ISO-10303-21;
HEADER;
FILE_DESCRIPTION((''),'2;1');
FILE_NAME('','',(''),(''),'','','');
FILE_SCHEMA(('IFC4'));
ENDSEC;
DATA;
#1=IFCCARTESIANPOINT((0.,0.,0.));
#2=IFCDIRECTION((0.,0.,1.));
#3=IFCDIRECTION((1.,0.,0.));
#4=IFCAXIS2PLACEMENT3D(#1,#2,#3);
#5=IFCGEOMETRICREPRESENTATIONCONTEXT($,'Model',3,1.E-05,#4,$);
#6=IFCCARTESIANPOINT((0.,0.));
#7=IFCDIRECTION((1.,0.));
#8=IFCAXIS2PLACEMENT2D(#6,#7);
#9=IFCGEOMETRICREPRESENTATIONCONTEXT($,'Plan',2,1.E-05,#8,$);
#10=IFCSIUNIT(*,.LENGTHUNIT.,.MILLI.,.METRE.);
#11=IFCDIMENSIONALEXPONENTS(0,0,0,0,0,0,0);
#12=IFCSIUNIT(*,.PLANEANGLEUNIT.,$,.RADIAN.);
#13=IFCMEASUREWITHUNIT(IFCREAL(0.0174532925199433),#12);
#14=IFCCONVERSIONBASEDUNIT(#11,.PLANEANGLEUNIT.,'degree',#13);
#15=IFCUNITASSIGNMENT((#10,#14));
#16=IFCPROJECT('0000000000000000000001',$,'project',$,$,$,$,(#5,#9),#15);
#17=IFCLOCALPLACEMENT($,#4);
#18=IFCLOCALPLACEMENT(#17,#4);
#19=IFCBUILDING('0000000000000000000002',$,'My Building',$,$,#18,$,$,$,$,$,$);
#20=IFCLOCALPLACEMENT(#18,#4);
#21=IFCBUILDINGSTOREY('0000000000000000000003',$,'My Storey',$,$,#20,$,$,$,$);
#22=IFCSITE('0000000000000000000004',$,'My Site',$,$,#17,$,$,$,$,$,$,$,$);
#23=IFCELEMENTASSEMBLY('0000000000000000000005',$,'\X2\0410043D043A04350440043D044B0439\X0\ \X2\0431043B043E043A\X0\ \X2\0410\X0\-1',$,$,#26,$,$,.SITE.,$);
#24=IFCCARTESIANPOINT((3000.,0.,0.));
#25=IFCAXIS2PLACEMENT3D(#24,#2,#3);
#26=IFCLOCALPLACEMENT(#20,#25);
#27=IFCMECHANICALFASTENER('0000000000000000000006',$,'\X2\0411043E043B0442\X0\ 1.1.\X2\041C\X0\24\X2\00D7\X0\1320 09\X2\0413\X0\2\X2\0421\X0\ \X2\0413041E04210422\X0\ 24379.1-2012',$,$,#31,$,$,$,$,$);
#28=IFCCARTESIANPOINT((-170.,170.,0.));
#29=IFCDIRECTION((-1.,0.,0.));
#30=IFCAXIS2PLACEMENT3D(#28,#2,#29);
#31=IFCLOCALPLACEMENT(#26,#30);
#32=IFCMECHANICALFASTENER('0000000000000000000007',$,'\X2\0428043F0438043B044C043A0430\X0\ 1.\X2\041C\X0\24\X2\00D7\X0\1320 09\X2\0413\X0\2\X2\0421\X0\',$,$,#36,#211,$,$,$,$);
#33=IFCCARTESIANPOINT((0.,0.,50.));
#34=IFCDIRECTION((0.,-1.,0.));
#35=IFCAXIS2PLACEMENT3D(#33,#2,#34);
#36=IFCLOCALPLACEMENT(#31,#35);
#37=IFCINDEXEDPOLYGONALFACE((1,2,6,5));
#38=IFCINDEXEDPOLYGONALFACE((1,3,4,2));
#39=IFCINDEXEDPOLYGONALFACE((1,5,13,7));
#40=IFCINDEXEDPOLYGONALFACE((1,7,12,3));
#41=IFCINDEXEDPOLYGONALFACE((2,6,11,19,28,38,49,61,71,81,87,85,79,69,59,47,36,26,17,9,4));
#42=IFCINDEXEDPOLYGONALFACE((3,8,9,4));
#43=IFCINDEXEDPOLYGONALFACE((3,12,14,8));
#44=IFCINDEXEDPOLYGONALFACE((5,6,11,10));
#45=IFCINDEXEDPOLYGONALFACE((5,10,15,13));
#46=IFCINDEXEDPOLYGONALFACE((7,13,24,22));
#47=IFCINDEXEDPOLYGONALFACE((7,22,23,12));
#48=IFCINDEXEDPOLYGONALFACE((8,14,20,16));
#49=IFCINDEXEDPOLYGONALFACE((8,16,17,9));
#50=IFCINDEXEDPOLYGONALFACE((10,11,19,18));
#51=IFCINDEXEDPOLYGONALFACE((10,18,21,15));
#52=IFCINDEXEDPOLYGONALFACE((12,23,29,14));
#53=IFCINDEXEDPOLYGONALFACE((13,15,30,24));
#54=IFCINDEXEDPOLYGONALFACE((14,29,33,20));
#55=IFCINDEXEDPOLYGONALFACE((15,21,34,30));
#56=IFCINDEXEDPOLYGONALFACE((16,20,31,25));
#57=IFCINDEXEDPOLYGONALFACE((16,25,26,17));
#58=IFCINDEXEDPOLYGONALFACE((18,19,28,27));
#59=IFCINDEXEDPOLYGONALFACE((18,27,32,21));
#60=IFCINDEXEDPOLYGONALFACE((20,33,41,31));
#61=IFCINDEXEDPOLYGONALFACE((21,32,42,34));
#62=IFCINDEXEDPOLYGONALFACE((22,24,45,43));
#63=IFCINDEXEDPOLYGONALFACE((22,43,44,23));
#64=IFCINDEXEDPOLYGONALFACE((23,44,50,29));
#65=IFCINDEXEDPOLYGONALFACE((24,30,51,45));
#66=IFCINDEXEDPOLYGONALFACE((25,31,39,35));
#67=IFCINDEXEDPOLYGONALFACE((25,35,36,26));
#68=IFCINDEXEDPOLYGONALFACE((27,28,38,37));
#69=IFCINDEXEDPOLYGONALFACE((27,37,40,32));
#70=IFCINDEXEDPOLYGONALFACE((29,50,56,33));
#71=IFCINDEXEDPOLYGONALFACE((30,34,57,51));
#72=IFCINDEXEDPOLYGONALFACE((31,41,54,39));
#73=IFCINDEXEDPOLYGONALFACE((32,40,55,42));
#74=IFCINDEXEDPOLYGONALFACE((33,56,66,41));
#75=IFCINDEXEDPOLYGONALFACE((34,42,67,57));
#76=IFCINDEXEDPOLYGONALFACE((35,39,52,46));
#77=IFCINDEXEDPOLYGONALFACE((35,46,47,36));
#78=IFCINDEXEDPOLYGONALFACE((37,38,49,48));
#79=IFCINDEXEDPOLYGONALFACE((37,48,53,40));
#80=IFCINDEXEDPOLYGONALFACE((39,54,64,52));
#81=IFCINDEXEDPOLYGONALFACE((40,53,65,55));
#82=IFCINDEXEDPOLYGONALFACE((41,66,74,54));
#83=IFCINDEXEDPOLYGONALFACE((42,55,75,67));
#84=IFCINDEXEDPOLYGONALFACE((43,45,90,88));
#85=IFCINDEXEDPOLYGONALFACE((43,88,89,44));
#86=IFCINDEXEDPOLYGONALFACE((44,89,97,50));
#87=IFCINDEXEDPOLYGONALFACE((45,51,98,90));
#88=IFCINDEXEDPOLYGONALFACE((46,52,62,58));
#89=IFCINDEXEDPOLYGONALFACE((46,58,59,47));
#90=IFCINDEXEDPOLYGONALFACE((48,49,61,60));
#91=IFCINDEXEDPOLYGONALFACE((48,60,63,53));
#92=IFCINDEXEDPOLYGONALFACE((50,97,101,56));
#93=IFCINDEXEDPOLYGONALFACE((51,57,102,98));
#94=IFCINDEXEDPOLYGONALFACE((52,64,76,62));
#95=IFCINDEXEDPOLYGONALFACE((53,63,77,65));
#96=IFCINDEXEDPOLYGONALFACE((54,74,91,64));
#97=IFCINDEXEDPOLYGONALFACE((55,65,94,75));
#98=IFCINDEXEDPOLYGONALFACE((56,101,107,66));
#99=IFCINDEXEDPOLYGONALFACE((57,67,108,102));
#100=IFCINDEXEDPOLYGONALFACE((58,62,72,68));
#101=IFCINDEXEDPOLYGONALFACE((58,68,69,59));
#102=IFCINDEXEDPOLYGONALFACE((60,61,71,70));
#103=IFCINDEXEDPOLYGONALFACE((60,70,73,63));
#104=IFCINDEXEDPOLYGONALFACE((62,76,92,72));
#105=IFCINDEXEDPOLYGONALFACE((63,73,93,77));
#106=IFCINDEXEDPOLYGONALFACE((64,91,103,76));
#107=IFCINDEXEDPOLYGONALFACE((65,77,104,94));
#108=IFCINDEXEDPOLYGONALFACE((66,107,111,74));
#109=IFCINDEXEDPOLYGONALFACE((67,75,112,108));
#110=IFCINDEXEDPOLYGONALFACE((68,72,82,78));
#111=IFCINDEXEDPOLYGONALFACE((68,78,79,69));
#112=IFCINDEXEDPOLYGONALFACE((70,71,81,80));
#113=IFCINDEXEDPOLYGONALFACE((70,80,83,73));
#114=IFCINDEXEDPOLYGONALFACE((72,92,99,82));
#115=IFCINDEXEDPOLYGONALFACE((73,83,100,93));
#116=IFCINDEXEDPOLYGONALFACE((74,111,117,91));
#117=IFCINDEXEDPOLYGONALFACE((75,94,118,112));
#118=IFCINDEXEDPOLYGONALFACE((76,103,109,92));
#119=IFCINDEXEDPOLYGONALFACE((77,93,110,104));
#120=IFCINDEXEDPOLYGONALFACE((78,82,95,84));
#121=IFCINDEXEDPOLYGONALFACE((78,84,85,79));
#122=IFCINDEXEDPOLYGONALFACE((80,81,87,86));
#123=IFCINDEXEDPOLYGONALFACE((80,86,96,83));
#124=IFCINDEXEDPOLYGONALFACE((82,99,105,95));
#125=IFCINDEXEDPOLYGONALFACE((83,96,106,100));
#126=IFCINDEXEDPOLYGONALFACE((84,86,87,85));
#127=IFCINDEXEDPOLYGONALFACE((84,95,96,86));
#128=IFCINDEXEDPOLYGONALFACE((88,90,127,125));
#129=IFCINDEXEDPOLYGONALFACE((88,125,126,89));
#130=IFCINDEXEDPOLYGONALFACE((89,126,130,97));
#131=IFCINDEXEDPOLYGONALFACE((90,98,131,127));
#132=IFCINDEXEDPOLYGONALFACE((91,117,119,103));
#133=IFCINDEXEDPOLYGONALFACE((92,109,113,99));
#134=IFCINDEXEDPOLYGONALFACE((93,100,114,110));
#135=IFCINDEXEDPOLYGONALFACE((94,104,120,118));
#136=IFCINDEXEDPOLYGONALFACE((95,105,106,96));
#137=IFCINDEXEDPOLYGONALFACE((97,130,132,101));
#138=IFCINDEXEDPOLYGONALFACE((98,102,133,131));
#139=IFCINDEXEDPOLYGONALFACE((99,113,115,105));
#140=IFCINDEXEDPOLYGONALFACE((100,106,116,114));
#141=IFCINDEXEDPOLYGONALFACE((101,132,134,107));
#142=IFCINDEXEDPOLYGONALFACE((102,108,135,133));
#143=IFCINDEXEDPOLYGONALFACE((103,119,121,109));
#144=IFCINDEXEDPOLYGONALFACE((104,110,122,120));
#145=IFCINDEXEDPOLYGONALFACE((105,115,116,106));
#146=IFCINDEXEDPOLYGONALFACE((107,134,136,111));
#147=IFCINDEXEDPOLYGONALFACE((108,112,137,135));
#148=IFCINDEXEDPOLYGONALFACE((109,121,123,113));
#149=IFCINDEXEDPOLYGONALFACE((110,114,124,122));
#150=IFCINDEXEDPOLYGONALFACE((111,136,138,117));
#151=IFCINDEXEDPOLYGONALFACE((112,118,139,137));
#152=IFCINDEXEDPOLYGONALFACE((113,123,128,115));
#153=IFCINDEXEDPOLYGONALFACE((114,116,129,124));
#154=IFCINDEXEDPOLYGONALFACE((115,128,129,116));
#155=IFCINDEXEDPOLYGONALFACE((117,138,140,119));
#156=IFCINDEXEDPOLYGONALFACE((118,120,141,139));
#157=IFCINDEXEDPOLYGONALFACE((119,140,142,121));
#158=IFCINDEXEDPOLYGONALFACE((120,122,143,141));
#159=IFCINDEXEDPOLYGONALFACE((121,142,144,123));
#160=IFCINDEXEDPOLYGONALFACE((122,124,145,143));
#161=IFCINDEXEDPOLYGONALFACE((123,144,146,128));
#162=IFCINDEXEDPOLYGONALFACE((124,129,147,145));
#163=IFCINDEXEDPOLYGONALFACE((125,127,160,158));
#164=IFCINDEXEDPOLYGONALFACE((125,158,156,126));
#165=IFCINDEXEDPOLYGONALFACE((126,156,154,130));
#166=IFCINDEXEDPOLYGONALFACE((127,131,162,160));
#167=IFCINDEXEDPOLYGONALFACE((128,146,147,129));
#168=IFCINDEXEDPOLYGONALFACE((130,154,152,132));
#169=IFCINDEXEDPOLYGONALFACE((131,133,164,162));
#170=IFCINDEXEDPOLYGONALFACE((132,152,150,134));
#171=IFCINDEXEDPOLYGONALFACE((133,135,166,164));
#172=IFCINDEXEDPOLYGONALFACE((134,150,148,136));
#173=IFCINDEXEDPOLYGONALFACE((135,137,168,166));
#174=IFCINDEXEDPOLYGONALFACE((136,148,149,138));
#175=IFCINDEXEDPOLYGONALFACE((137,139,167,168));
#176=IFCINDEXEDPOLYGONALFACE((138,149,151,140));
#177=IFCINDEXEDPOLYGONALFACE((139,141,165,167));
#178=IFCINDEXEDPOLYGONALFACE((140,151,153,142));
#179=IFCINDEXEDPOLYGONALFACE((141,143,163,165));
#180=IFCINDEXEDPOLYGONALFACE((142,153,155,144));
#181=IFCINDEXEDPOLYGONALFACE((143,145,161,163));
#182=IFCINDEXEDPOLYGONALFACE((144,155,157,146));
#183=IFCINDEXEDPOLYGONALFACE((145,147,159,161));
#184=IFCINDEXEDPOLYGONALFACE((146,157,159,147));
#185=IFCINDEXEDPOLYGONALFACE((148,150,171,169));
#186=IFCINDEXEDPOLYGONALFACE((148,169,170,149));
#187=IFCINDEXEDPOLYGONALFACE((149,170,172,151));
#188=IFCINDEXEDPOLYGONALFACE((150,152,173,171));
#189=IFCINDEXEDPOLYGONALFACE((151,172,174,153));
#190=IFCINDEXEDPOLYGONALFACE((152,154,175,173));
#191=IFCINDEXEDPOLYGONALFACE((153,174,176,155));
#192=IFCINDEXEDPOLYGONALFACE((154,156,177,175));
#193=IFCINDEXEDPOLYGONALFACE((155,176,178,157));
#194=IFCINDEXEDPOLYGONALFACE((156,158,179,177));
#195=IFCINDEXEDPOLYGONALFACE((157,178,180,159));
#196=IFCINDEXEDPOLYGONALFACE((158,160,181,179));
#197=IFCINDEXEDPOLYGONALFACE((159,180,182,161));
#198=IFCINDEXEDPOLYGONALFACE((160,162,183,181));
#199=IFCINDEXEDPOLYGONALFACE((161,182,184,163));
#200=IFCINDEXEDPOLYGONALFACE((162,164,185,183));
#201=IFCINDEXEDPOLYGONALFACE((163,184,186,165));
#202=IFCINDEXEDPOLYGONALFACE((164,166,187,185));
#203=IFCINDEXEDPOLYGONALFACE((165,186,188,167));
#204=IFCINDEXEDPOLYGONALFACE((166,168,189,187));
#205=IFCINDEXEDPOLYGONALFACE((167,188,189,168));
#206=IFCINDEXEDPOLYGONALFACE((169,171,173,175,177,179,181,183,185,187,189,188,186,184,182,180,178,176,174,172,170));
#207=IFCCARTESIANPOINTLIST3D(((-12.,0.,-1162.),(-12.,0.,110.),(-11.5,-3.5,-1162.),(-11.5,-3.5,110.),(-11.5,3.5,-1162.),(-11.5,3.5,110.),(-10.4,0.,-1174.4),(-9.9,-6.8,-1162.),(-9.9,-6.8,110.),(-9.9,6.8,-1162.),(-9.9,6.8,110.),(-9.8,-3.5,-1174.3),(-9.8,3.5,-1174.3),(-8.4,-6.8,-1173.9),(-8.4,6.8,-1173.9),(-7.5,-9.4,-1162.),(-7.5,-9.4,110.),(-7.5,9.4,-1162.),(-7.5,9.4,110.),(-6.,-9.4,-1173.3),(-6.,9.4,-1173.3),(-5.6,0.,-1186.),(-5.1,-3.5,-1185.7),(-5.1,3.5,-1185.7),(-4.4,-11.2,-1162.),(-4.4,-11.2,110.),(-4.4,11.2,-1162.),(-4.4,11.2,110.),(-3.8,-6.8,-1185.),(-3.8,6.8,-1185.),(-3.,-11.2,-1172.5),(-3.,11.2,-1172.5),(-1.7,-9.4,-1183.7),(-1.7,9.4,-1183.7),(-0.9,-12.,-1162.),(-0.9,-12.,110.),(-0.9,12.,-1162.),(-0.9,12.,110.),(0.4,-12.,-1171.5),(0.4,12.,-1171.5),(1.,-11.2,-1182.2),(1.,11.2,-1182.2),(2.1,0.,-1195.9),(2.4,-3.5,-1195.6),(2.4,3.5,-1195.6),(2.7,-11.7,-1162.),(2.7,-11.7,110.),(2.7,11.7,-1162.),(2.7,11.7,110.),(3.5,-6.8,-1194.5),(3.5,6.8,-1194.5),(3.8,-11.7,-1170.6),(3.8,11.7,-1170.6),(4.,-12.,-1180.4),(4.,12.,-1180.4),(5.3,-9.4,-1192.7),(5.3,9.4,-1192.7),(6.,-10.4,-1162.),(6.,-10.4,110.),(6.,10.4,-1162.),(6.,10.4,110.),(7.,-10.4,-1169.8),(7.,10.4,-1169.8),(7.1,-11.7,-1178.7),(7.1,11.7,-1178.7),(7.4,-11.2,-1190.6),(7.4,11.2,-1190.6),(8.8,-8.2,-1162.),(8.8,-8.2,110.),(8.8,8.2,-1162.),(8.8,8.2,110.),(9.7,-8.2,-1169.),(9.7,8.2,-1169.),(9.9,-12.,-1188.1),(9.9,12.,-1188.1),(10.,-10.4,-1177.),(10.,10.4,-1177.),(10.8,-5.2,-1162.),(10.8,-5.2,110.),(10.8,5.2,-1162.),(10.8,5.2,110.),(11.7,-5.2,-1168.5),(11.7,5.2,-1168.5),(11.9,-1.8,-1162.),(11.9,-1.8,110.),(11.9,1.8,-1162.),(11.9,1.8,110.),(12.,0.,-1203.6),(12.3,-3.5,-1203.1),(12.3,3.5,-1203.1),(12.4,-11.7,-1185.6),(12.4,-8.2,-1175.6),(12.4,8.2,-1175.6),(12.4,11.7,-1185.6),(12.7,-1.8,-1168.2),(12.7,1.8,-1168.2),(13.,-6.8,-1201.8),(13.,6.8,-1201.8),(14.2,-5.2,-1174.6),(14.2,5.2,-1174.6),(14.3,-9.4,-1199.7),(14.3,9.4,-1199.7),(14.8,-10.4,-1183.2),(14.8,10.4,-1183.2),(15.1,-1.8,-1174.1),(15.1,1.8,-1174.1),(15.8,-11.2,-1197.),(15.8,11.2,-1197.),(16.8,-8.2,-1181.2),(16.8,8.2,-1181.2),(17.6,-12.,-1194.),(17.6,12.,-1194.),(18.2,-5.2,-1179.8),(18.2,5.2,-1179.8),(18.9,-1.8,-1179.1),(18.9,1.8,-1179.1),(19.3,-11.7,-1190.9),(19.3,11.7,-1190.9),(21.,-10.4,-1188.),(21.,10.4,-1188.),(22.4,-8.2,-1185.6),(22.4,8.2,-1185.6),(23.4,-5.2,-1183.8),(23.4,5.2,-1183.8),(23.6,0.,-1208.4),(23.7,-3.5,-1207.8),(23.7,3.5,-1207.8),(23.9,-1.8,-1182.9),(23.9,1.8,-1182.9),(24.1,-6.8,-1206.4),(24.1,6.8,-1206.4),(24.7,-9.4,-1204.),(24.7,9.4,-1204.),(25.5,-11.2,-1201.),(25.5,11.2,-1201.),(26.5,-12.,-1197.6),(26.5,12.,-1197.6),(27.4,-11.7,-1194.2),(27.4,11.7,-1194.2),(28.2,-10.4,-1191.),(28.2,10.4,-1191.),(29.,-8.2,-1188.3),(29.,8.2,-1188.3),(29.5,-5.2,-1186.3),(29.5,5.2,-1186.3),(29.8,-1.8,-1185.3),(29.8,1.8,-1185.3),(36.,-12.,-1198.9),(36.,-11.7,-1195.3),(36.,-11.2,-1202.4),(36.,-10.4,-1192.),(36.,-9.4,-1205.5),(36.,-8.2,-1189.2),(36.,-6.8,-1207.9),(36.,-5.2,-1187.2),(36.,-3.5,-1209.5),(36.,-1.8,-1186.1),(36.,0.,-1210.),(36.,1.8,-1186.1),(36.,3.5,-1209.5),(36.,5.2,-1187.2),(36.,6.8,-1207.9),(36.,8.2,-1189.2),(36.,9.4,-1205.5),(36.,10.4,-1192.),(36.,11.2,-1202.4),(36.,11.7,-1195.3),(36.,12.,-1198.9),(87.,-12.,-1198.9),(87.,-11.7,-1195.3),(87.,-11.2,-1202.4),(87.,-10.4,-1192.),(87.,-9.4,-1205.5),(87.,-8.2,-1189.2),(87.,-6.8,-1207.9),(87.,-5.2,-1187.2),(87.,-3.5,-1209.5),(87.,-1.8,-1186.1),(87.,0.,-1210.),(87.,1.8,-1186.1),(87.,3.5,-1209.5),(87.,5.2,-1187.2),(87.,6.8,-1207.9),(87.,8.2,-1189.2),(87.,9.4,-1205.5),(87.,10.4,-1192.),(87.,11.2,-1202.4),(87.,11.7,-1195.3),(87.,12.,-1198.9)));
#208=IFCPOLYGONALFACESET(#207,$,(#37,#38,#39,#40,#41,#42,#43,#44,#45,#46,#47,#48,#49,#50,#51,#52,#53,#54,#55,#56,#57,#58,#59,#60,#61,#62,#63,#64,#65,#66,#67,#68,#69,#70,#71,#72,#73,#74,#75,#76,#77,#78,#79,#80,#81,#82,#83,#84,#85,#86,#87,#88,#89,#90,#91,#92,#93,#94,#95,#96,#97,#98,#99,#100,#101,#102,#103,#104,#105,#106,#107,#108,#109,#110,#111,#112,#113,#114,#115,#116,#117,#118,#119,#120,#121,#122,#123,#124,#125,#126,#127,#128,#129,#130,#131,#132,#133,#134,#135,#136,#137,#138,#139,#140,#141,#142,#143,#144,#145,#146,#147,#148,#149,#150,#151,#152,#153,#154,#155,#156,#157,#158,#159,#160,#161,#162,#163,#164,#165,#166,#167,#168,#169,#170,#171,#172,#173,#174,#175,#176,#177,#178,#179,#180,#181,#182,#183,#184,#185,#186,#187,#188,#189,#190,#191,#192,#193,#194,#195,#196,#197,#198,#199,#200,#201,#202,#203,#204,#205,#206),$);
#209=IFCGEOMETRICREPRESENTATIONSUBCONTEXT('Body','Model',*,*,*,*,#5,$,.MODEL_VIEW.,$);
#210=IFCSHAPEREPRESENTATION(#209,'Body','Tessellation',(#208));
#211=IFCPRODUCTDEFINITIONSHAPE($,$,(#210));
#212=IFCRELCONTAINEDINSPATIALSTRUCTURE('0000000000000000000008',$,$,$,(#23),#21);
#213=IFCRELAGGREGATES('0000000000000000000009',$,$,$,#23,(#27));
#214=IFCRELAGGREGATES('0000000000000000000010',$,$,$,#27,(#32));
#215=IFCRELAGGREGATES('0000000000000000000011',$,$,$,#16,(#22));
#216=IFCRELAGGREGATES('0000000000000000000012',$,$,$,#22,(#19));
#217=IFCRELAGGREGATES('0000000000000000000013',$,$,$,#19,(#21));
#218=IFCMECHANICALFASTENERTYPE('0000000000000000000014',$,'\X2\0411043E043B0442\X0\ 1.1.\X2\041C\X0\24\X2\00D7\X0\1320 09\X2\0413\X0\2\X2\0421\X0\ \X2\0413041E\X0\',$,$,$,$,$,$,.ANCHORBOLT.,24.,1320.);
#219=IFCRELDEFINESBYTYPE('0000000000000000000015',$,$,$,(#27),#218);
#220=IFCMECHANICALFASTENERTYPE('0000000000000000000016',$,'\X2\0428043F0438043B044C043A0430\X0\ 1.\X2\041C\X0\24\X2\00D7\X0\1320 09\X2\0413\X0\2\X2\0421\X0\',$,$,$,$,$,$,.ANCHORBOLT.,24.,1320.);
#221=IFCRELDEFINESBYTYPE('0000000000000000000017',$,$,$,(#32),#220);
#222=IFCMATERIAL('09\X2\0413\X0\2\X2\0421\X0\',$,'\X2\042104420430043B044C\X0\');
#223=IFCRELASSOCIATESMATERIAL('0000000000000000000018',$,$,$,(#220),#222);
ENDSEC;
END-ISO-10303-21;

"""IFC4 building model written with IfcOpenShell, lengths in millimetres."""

from ifc_helpers import new_model, entity, si_unit, converted_unit, frame, origin_with_axes, origin_2d_with_axis, place, context, subcontext, project, spatial, source, transform, mapped, material, type_object, type_shapes, element, aggregate, save


model = new_model("IFC4")

# Units and contexts
model_context = context("Model", 3, precision=1e-05, world=origin_with_axes())
plan_context = context("Plan", 2, precision=1e-05, world=origin_2d_with_axis())
body_context = subcontext(model_context, "Body", "Model", "MODEL_VIEW")
ifc_project = project(units=[si_unit("LENGTHUNIT", "METRE", prefix="MILLI"), converted_unit("PLANEANGLEUNIT", "degree", entity("IfcReal", 0.0174532925199433), si_unit("PLANEANGLEUNIT", "RADIAN"), dimensions=[0, 0, 0, 0, 0, 0, 0])], contexts=[model_context, plan_context])

# Site, building, storey
site_placement = place(None, origin_with_axes())
site = spatial("IfcSite", under=ifc_project, at=site_placement, Name="My Site")
building_placement = place(site_placement, origin_with_axes())
building = spatial("IfcBuilding", under=site, at=building_placement, Name="My Building")
storey_placement = place(building_placement, origin_with_axes())
storey = spatial("IfcBuildingStorey", under=building, at=storey_placement, Name="My Storey")

# Element assembly, mechanical fasteners
assembly_placement = place(storey_placement, frame((3000.0, 0.0, 0.0), z_axis=(0.0, 0.0, 1.0), x_axis=(1.0, 0.0, 0.0)))
assembly = element("IfcElementAssembly", 1, at=assembly_placement, inside=storey, Name="Анкерный блок А-1", AssemblyPlace="SITE")
mechanical_fastener_type_1 = type_object("IfcMechanicalFastenerType", Name="Болт 1.1.М24×1320 09Г2С ГО", NominalDiameter=24.0, NominalLength=1320.0, PredefinedType="ANCHORBOLT")
mechanical_fastener_1_placement = place(assembly_placement, frame((-170.0, 170.0, 0.0), z_axis=(0.0, 0.0, 1.0), x_axis=(-1.0, 0.0, 0.0)))
mechanical_fastener_1 = element("IfcMechanicalFastener", 2, at=mechanical_fastener_1_placement, type_object=mechanical_fastener_type_1, Name="Болт 1.1.М24×1320 09Г2С ГОСТ 24379.1-2012")
ifc_material_1 = material(Name="09Г2С", Category="Сталь")
mechanical_fastener_type_2 = type_object("IfcMechanicalFastenerType", Name="Шпилька 1.М24×1320 09Г2С", NominalDiameter=24.0, NominalLength=1320.0, PredefinedType="ANCHORBOLT", material=ifc_material_1)
shared_shape_1 = source(frame((0.0, 0.0, 110.0), z_axis=(0.0, 0.0, 1.0), x_axis=(1.0, 0.0, 0.0)), body_context, "Body", "AdvancedSweptSolid", [
    entity("IfcSweptDiskSolid", entity("IfcIndexedPolyCurve", entity("IfcCartesianPointList3D", [[0.0, 0.0, 0.0], [0.0, 0.0, -1272.0], [10.5, 0.0, -1297.5], [36.0, 0.0, -1308.0], [87.0, 0.0, -1308.0]]), [entity("IfcLineIndex", [1, 2]), entity("IfcArcIndex", [2, 3, 4]), entity("IfcLineIndex", [4, 5])]), 12.0),
])
type_shapes(mechanical_fastener_type_2, [shared_shape_1])
mechanical_fastener_2_placement = place(mechanical_fastener_1_placement, frame((0.0, 0.0, 50.0), z_axis=(0.0, 0.0, 1.0), x_axis=(0.0, -1.0, 0.0)))
mechanical_fastener_2 = element("IfcMechanicalFastener", 3, at=mechanical_fastener_2_placement, type_object=mechanical_fastener_type_2, Name="Шпилька 1.М24×1320 09Г2С", context=body_context, shape_type="MappedRepresentation", body=[
    mapped(shared_shape_1, transform((0.0, 0.0, 0.0), x_axis=(1.0, 0.0, 0.0), y_axis=(0.0, 1.0, 0.0), z_axis=(0.0, 0.0, 1.0), scale=1.0)),
])
aggregate(assembly, [mechanical_fastener_1])
aggregate(mechanical_fastener_1, [mechanical_fastener_2])

save(model, "model.ifc")
